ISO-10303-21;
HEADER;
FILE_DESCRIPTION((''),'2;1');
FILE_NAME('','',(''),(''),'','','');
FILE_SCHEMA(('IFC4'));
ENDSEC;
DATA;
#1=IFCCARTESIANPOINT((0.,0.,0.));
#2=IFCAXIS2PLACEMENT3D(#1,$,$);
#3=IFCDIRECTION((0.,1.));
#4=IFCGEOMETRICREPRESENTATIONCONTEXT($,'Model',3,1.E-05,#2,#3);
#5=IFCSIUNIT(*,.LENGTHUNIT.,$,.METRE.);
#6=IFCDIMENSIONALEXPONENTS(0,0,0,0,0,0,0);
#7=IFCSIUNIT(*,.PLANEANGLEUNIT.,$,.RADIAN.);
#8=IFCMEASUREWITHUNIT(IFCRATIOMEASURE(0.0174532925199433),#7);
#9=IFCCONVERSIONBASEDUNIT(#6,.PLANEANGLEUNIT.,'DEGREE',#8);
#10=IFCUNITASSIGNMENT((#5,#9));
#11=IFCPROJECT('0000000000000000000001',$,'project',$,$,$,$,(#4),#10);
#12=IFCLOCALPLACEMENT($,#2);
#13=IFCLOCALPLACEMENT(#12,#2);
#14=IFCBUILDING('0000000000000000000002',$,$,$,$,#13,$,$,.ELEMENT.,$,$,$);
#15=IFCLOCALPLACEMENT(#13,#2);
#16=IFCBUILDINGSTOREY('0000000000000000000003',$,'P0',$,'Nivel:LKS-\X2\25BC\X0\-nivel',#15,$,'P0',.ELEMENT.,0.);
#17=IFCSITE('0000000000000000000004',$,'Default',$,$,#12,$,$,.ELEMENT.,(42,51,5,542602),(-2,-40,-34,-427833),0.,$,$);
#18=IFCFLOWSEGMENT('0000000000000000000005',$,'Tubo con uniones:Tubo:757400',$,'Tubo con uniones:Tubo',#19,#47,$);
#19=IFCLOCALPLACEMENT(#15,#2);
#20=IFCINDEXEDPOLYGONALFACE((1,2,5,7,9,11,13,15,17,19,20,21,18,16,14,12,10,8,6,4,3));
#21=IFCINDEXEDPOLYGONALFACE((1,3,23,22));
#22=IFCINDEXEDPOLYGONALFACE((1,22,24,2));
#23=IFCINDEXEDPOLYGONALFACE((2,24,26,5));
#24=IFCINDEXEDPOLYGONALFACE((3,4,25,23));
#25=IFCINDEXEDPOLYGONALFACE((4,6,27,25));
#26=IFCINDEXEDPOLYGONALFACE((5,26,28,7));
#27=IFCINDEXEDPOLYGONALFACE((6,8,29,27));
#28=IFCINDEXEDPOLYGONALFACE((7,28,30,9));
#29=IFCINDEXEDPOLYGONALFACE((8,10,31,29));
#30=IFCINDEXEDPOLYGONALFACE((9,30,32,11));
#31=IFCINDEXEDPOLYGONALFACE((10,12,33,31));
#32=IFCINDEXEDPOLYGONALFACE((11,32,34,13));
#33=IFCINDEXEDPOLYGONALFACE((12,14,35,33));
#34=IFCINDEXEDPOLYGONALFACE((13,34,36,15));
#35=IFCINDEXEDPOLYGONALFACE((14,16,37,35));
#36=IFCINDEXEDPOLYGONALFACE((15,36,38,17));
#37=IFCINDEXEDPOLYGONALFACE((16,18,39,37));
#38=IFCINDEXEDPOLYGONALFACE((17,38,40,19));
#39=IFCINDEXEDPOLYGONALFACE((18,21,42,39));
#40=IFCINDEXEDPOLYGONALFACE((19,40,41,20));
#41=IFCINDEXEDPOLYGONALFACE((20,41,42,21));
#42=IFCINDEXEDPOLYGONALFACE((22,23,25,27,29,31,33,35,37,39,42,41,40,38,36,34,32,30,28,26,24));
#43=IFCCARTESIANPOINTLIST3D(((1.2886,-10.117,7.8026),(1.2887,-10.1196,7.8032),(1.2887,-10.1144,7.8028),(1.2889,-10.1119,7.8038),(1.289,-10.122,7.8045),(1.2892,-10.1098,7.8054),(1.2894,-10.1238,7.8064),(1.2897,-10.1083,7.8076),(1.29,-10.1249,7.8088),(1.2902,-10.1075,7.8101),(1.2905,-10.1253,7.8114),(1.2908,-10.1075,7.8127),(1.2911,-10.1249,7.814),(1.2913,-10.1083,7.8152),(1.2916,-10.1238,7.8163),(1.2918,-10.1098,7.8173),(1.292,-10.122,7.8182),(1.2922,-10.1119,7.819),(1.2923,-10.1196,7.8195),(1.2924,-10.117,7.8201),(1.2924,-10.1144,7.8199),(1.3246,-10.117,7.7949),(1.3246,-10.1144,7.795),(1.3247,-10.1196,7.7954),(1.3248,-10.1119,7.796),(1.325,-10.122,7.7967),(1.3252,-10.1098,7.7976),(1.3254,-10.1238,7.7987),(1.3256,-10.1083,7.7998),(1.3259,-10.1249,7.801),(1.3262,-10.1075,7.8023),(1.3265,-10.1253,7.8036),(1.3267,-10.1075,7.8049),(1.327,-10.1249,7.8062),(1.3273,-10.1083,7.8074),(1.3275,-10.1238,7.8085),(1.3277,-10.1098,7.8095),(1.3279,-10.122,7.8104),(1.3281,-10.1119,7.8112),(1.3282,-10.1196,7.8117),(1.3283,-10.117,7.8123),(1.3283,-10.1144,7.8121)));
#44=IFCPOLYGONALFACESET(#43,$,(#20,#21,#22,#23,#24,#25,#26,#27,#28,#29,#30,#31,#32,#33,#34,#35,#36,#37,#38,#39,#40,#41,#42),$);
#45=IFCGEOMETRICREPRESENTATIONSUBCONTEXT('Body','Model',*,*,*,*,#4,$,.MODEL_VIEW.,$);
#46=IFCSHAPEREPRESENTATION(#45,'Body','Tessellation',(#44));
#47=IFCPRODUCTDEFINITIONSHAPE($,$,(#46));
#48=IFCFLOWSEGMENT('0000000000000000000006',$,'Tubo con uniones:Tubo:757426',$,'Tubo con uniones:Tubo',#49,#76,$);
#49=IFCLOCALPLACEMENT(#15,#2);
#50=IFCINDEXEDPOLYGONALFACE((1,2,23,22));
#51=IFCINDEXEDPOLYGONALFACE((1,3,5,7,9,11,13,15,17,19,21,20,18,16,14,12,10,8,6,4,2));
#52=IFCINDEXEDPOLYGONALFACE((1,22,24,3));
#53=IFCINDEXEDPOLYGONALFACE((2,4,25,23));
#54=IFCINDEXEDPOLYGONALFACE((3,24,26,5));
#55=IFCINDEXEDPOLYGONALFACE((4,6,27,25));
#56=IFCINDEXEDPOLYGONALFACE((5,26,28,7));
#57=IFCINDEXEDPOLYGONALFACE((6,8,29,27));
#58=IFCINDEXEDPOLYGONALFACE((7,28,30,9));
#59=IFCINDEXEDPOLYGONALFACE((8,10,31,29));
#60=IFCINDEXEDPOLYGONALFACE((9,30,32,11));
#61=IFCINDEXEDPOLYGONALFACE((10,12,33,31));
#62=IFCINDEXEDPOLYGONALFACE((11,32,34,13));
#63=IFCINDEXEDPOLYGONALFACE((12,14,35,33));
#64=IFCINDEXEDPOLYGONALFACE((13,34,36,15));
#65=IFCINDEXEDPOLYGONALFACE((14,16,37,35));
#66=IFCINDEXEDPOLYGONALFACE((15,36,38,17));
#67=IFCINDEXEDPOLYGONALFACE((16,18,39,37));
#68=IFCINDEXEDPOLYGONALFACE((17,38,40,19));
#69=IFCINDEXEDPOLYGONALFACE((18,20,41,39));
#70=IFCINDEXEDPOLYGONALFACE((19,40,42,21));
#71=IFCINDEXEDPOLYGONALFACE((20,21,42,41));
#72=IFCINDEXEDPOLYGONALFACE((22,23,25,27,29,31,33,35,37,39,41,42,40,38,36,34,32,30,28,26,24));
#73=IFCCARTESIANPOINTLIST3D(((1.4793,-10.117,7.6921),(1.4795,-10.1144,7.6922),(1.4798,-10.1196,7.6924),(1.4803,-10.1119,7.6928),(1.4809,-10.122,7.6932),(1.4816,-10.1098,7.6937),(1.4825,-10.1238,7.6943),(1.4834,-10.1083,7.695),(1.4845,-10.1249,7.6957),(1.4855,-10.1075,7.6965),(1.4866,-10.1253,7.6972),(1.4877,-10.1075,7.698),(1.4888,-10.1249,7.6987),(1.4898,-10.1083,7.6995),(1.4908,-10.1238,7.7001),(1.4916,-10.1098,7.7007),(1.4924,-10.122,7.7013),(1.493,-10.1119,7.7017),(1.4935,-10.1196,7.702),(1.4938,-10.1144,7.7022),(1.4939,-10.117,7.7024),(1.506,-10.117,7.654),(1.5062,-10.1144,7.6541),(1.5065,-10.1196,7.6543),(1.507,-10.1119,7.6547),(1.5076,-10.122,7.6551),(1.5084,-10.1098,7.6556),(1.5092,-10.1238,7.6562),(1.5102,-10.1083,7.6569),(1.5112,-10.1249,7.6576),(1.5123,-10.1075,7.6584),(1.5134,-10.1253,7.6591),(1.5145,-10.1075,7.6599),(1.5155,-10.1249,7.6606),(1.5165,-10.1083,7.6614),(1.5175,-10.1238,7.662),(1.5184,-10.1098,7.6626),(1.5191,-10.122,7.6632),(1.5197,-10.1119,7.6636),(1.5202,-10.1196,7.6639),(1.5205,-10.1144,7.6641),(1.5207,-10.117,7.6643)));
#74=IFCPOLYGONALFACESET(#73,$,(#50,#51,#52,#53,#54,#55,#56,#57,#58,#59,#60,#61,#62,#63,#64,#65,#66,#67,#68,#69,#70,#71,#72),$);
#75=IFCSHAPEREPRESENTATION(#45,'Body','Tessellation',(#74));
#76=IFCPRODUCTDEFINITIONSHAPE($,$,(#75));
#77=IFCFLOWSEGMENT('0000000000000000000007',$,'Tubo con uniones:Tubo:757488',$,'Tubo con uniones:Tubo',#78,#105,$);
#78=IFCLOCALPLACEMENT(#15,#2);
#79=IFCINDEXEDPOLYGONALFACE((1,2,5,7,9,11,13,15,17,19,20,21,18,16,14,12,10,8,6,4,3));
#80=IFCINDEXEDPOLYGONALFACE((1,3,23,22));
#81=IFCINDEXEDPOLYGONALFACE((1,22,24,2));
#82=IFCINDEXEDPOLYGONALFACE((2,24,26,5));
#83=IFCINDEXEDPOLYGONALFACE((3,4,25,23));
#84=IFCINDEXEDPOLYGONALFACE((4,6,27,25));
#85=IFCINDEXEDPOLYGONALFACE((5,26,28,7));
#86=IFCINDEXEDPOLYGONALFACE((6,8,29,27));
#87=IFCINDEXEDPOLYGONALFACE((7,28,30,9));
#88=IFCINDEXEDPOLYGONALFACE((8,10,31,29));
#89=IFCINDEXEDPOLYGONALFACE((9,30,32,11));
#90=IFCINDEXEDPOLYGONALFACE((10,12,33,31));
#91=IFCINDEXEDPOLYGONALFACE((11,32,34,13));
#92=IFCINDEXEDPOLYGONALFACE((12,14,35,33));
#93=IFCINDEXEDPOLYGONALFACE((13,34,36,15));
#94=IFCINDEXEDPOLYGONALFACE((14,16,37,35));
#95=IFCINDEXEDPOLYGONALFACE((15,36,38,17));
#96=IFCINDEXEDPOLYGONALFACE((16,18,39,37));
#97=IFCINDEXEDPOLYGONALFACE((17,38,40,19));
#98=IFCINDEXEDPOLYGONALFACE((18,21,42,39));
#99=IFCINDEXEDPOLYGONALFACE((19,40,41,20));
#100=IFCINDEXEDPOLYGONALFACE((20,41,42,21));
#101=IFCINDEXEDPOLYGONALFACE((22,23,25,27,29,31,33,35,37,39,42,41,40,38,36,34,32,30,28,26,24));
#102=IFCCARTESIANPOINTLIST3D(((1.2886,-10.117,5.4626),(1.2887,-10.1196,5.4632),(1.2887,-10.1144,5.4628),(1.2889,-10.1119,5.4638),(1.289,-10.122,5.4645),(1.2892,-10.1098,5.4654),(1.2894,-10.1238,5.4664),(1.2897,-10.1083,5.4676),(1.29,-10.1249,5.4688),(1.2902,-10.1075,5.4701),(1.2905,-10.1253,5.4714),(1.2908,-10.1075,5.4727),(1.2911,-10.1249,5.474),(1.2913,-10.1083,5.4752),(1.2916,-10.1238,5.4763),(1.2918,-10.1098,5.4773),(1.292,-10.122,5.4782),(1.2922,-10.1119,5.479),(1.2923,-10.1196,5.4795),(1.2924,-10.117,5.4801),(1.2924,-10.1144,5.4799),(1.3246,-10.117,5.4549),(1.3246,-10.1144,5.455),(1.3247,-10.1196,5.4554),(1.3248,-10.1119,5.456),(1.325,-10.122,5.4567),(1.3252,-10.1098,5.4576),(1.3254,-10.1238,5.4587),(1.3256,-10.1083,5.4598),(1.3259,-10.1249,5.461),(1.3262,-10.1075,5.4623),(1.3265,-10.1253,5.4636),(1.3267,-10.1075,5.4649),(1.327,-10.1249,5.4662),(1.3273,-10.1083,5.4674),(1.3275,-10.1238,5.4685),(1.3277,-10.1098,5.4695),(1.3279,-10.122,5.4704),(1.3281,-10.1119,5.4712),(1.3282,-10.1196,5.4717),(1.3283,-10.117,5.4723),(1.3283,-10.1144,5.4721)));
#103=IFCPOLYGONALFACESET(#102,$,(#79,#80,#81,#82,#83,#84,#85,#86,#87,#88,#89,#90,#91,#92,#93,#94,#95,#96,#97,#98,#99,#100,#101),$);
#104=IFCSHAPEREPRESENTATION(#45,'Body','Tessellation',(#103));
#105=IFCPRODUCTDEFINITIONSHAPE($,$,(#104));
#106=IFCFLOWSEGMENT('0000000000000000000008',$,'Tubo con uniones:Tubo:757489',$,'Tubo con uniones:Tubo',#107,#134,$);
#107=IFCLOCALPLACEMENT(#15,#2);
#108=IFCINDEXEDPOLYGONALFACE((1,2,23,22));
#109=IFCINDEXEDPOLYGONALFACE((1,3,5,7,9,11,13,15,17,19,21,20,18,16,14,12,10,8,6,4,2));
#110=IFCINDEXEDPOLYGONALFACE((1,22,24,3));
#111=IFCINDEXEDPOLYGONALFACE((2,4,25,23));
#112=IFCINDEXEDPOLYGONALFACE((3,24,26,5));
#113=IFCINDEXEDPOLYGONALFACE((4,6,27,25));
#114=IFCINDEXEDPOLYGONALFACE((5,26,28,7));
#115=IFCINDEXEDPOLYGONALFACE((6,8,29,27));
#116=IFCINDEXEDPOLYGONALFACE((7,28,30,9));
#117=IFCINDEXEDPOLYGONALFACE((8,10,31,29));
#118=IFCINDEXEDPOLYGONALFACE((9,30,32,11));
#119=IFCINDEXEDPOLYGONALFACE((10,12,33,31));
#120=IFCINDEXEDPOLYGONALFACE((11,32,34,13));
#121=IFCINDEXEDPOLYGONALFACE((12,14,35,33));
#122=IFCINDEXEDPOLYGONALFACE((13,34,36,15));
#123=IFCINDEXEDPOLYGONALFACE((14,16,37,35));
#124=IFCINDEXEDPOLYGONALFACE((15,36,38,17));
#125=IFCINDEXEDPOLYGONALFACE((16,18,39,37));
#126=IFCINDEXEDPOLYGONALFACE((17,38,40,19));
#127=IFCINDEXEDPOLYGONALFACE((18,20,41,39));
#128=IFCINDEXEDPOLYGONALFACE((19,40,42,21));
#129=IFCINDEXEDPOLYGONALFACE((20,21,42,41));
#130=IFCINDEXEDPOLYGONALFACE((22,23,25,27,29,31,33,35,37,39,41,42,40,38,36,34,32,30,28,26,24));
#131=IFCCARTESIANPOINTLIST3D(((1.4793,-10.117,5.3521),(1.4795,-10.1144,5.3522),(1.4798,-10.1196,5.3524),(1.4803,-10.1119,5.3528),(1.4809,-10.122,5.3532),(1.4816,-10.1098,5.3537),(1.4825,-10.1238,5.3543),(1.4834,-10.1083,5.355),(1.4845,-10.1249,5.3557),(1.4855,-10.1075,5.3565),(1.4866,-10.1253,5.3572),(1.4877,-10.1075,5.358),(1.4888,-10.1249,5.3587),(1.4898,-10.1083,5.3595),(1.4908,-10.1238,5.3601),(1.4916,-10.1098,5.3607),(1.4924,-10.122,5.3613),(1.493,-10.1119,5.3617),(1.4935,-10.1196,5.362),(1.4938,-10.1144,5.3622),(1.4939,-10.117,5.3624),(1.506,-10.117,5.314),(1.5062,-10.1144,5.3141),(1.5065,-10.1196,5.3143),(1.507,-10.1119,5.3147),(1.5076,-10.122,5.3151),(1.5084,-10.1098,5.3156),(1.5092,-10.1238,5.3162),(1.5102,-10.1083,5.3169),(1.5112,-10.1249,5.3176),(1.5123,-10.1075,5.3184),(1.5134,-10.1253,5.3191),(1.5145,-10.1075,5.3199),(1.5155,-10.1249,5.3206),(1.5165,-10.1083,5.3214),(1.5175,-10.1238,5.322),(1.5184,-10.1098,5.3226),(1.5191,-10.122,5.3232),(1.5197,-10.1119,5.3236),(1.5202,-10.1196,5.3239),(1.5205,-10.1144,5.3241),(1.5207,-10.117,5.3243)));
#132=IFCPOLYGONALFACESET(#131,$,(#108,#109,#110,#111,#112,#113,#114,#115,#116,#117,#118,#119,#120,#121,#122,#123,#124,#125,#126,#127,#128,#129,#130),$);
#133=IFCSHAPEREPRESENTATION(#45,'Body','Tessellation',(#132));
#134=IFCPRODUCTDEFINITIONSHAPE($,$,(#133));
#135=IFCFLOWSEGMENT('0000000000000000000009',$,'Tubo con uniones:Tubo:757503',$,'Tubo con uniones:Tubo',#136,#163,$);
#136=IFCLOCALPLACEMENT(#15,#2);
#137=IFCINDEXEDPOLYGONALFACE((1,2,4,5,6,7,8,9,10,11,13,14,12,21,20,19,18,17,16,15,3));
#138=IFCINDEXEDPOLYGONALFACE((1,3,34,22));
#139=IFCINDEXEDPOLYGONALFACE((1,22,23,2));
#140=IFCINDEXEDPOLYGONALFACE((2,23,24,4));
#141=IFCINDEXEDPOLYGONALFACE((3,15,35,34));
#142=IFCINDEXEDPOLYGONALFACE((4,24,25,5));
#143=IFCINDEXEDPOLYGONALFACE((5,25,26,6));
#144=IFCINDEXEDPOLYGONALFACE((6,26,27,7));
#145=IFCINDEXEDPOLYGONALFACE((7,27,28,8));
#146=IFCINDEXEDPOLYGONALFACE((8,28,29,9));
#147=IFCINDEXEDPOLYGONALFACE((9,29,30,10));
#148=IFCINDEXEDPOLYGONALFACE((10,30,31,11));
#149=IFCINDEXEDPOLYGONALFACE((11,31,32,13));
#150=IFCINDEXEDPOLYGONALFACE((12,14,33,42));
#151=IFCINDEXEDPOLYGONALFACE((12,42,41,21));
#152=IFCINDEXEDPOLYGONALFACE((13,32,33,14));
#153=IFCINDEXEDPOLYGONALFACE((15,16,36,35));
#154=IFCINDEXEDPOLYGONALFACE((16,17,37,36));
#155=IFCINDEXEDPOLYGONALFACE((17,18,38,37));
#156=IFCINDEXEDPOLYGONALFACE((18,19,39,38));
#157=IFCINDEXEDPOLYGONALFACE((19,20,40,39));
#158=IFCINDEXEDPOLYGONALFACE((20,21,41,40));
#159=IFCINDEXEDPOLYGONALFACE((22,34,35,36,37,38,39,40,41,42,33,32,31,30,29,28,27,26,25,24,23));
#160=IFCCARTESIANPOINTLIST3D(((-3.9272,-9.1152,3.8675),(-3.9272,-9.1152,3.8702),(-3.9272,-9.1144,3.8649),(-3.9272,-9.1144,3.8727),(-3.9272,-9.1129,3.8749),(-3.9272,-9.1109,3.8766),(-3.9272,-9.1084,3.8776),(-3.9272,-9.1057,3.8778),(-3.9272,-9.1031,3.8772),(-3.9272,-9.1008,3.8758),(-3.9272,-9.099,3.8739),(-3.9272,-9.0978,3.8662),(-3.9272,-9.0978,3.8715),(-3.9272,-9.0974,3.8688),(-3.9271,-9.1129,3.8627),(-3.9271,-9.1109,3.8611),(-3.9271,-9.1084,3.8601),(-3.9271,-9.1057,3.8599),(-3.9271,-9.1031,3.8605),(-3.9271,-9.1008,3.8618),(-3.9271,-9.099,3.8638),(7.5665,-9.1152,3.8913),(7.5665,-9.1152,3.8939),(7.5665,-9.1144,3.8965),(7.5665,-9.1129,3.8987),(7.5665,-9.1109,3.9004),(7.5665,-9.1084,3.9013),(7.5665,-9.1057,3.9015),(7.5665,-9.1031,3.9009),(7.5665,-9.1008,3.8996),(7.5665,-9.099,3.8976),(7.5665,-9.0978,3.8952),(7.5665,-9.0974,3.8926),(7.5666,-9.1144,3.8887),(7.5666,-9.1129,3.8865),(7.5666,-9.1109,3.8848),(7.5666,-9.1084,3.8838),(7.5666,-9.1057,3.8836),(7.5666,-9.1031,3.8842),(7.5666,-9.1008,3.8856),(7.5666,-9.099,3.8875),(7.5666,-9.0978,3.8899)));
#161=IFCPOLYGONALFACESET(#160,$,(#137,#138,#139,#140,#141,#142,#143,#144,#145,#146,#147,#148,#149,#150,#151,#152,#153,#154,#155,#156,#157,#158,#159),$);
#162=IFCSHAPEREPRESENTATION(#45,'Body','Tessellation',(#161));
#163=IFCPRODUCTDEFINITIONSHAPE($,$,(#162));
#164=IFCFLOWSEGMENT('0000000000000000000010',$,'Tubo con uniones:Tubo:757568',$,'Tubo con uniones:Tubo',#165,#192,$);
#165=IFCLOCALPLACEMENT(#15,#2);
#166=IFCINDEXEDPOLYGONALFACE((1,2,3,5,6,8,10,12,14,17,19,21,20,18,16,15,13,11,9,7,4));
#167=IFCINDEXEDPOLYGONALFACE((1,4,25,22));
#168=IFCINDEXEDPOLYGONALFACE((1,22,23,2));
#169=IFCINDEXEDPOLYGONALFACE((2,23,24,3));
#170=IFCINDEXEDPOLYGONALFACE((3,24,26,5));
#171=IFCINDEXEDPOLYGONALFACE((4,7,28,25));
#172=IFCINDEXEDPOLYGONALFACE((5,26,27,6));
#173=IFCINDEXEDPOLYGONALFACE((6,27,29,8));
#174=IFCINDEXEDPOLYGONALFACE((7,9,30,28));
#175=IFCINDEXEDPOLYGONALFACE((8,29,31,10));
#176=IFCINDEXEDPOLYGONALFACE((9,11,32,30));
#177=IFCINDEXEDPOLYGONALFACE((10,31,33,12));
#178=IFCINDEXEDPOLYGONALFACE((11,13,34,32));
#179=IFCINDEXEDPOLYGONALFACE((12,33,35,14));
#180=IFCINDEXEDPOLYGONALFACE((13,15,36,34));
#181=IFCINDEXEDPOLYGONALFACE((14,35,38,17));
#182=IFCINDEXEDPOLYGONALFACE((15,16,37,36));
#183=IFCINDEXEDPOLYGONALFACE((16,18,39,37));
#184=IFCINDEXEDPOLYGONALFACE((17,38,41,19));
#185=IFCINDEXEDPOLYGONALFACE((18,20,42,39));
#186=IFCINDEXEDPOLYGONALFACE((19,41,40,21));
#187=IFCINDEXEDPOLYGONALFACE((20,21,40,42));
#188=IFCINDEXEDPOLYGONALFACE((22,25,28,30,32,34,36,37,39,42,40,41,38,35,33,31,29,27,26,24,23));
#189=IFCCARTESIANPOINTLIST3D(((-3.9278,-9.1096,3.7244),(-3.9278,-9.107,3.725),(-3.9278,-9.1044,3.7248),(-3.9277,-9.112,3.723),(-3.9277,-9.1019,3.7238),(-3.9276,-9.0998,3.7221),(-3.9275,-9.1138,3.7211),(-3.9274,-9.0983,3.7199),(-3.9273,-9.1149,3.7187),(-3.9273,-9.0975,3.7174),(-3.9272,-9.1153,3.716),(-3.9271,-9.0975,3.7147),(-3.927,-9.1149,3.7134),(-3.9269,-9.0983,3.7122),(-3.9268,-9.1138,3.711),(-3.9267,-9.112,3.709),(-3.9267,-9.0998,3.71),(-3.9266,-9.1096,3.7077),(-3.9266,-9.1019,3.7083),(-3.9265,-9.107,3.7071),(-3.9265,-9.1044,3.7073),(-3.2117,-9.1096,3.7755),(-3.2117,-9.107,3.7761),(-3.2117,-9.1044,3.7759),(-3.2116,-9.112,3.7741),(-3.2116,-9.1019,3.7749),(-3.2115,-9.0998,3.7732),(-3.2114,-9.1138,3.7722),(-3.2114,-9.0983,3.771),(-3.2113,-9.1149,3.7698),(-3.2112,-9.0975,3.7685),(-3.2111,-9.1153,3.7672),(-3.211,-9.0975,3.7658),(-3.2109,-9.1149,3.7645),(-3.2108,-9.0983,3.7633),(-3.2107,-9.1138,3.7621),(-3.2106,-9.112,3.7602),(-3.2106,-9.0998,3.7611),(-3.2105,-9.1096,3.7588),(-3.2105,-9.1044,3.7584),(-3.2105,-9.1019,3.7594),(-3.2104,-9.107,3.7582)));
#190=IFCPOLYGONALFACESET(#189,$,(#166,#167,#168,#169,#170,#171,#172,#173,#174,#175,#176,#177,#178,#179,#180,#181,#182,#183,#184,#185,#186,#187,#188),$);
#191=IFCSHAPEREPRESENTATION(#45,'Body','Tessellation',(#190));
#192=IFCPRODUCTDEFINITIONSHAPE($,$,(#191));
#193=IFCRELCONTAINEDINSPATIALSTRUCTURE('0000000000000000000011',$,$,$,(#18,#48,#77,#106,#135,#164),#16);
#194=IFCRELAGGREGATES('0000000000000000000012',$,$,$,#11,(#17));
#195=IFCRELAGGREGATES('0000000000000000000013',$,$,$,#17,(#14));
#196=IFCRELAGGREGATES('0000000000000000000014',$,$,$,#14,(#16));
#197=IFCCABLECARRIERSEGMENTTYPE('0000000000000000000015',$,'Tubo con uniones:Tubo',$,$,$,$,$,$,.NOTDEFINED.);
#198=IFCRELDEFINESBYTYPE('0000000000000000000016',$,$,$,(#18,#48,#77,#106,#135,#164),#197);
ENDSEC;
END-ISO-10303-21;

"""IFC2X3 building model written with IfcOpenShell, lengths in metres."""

from ifc_helpers import new_model, entity, si_unit, converted_unit, direction, frame, frame_2d, origin, origin_2d_with_axis, place, context, subcontext, project, spatial, circle, extrude, type_object, element, save


model = new_model("IFC2X3")

# Units and contexts
model_context = context("Model", 3, precision=1e-05, world=origin(), true_north=direction((0.0, 1.0)))
body_context = subcontext(model_context, "Body", "Model", "MODEL_VIEW")
ifc_project = project(units=[si_unit("LENGTHUNIT", "METRE"), converted_unit("PLANEANGLEUNIT", "DEGREE", entity("IfcRatioMeasure", 0.0174532925199433), si_unit("PLANEANGLEUNIT", "RADIAN"), dimensions=[0, 0, 0, 0, 0, 0, 0])], contexts=[model_context])

# Site, building, storey
site_placement = place(None, origin())
site = spatial("IfcSite", under=ifc_project, at=site_placement, Name="Default", CompositionType="ELEMENT", RefLatitude=(42, 51, 5, 542602), RefLongitude=(-2, -40, -34, -427833), RefElevation=0.0)
building_placement = place(site_placement, origin())
building = spatial("IfcBuilding", under=site, at=building_placement, CompositionType="ELEMENT")
storey_placement = place(building_placement, origin())
storey = spatial("IfcBuildingStorey", under=building, at=storey_placement, Name="P0", ObjectType="Nivel:LKS-▼-nivel", LongName="P0", CompositionType="ELEMENT", Elevation=0.0)

# Flow segments
cable_carrier_segment_type = type_object("IfcCableCarrierSegmentType", Name="Tubo con uniones:Tubo", PredefinedType="NOTDEFINED")
flow_segment_1_placement = place(storey_placement, origin())
element("IfcFlowSegment", 1, at=flow_segment_1_placement, inside=storey, type_object=cable_carrier_segment_type, Name="Tubo con uniones:Tubo:757400", ObjectType="Tubo con uniones:Tubo", context=body_context, shape_type="SweptSolid", body=[
    extrude(circle(Radius=0.009, at=frame_2d((0.0, 0.0), x_axis=(1.0, 0.0))), frame((1.3265, -10.1164, 7.8036), z_axis=(-0.977306, 0.0, 0.211834), x_axis=(0.0, -1.0, 0.0)), (0.0, 0.0, 1.0), 0.0368),
])
flow_segment_2_placement = place(storey_placement, origin())
element("IfcFlowSegment", 2, at=flow_segment_2_placement, inside=storey, type_object=cable_carrier_segment_type, Name="Tubo con uniones:Tubo:757426", ObjectType="Tubo con uniones:Tubo", context=body_context, shape_type="SweptSolid", body=[
    extrude(circle(Radius=0.009, at=origin_2d_with_axis()), frame((1.4866, -10.1164, 7.6972), z_axis=(0.574412, 0.0, -0.818567), x_axis=(0.0, -1.0, 0.0)), (0.0, 0.0, 1.0), 0.0465),
])
flow_segment_3_placement = place(storey_placement, origin())
element("IfcFlowSegment", 3, at=flow_segment_3_placement, inside=storey, type_object=cable_carrier_segment_type, Name="Tubo con uniones:Tubo:757488", ObjectType="Tubo con uniones:Tubo", context=body_context, shape_type="SweptSolid", body=[
    extrude(circle(Radius=0.009, at=frame_2d((0.0, 0.0), x_axis=(1.0, 0.0))), frame((1.3265, -10.1164, 5.4636), z_axis=(-0.977306, 0.0, 0.211834), x_axis=(0.0, -1.0, 0.0)), (0.0, 0.0, 1.0), 0.0368),
])
flow_segment_4_placement = place(storey_placement, origin())
element("IfcFlowSegment", 4, at=flow_segment_4_placement, inside=storey, type_object=cable_carrier_segment_type, Name="Tubo con uniones:Tubo:757489", ObjectType="Tubo con uniones:Tubo", context=body_context, shape_type="SweptSolid", body=[
    extrude(circle(Radius=0.009, at=origin_2d_with_axis()), frame((1.4866, -10.1164, 5.3572), z_axis=(0.574412, 0.0, -0.818567), x_axis=(0.0, -1.0, 0.0)), (0.0, 0.0, 1.0), 0.0465),
])
flow_segment_5_placement = place(storey_placement, origin())
element("IfcFlowSegment", 5, at=flow_segment_5_placement, inside=storey, type_object=cable_carrier_segment_type, Name="Tubo con uniones:Tubo:757503", ObjectType="Tubo con uniones:Tubo", context=body_context, shape_type="SweptSolid", body=[
    extrude(circle(Radius=0.009, at=frame_2d((0.0, 0.0), x_axis=(1.0, 0.0))), frame((-3.9272, -9.1064, 3.8688), z_axis=(0.999998, 0.0, 0.002069), x_axis=(0.0, 1.0, 0.0)), (0.0, 0.0, 1.0), 11.4937),
])
flow_segment_6_placement = place(storey_placement, origin())
element("IfcFlowSegment", 6, at=flow_segment_6_placement, inside=storey, type_object=cable_carrier_segment_type, Name="Tubo con uniones:Tubo:757568", ObjectType="Tubo con uniones:Tubo", context=body_context, shape_type="SweptSolid", body=[
    extrude(circle(Radius=0.009, at=origin_2d_with_axis()), frame((-3.9272, -9.1064, 3.716), z_axis=(0.997461, 0.0, 0.07121), x_axis=(0.0, -1.0, 0.0)), (0.0, 0.0, 1.0), 0.7179),
])

save(model, "model.ifc")
